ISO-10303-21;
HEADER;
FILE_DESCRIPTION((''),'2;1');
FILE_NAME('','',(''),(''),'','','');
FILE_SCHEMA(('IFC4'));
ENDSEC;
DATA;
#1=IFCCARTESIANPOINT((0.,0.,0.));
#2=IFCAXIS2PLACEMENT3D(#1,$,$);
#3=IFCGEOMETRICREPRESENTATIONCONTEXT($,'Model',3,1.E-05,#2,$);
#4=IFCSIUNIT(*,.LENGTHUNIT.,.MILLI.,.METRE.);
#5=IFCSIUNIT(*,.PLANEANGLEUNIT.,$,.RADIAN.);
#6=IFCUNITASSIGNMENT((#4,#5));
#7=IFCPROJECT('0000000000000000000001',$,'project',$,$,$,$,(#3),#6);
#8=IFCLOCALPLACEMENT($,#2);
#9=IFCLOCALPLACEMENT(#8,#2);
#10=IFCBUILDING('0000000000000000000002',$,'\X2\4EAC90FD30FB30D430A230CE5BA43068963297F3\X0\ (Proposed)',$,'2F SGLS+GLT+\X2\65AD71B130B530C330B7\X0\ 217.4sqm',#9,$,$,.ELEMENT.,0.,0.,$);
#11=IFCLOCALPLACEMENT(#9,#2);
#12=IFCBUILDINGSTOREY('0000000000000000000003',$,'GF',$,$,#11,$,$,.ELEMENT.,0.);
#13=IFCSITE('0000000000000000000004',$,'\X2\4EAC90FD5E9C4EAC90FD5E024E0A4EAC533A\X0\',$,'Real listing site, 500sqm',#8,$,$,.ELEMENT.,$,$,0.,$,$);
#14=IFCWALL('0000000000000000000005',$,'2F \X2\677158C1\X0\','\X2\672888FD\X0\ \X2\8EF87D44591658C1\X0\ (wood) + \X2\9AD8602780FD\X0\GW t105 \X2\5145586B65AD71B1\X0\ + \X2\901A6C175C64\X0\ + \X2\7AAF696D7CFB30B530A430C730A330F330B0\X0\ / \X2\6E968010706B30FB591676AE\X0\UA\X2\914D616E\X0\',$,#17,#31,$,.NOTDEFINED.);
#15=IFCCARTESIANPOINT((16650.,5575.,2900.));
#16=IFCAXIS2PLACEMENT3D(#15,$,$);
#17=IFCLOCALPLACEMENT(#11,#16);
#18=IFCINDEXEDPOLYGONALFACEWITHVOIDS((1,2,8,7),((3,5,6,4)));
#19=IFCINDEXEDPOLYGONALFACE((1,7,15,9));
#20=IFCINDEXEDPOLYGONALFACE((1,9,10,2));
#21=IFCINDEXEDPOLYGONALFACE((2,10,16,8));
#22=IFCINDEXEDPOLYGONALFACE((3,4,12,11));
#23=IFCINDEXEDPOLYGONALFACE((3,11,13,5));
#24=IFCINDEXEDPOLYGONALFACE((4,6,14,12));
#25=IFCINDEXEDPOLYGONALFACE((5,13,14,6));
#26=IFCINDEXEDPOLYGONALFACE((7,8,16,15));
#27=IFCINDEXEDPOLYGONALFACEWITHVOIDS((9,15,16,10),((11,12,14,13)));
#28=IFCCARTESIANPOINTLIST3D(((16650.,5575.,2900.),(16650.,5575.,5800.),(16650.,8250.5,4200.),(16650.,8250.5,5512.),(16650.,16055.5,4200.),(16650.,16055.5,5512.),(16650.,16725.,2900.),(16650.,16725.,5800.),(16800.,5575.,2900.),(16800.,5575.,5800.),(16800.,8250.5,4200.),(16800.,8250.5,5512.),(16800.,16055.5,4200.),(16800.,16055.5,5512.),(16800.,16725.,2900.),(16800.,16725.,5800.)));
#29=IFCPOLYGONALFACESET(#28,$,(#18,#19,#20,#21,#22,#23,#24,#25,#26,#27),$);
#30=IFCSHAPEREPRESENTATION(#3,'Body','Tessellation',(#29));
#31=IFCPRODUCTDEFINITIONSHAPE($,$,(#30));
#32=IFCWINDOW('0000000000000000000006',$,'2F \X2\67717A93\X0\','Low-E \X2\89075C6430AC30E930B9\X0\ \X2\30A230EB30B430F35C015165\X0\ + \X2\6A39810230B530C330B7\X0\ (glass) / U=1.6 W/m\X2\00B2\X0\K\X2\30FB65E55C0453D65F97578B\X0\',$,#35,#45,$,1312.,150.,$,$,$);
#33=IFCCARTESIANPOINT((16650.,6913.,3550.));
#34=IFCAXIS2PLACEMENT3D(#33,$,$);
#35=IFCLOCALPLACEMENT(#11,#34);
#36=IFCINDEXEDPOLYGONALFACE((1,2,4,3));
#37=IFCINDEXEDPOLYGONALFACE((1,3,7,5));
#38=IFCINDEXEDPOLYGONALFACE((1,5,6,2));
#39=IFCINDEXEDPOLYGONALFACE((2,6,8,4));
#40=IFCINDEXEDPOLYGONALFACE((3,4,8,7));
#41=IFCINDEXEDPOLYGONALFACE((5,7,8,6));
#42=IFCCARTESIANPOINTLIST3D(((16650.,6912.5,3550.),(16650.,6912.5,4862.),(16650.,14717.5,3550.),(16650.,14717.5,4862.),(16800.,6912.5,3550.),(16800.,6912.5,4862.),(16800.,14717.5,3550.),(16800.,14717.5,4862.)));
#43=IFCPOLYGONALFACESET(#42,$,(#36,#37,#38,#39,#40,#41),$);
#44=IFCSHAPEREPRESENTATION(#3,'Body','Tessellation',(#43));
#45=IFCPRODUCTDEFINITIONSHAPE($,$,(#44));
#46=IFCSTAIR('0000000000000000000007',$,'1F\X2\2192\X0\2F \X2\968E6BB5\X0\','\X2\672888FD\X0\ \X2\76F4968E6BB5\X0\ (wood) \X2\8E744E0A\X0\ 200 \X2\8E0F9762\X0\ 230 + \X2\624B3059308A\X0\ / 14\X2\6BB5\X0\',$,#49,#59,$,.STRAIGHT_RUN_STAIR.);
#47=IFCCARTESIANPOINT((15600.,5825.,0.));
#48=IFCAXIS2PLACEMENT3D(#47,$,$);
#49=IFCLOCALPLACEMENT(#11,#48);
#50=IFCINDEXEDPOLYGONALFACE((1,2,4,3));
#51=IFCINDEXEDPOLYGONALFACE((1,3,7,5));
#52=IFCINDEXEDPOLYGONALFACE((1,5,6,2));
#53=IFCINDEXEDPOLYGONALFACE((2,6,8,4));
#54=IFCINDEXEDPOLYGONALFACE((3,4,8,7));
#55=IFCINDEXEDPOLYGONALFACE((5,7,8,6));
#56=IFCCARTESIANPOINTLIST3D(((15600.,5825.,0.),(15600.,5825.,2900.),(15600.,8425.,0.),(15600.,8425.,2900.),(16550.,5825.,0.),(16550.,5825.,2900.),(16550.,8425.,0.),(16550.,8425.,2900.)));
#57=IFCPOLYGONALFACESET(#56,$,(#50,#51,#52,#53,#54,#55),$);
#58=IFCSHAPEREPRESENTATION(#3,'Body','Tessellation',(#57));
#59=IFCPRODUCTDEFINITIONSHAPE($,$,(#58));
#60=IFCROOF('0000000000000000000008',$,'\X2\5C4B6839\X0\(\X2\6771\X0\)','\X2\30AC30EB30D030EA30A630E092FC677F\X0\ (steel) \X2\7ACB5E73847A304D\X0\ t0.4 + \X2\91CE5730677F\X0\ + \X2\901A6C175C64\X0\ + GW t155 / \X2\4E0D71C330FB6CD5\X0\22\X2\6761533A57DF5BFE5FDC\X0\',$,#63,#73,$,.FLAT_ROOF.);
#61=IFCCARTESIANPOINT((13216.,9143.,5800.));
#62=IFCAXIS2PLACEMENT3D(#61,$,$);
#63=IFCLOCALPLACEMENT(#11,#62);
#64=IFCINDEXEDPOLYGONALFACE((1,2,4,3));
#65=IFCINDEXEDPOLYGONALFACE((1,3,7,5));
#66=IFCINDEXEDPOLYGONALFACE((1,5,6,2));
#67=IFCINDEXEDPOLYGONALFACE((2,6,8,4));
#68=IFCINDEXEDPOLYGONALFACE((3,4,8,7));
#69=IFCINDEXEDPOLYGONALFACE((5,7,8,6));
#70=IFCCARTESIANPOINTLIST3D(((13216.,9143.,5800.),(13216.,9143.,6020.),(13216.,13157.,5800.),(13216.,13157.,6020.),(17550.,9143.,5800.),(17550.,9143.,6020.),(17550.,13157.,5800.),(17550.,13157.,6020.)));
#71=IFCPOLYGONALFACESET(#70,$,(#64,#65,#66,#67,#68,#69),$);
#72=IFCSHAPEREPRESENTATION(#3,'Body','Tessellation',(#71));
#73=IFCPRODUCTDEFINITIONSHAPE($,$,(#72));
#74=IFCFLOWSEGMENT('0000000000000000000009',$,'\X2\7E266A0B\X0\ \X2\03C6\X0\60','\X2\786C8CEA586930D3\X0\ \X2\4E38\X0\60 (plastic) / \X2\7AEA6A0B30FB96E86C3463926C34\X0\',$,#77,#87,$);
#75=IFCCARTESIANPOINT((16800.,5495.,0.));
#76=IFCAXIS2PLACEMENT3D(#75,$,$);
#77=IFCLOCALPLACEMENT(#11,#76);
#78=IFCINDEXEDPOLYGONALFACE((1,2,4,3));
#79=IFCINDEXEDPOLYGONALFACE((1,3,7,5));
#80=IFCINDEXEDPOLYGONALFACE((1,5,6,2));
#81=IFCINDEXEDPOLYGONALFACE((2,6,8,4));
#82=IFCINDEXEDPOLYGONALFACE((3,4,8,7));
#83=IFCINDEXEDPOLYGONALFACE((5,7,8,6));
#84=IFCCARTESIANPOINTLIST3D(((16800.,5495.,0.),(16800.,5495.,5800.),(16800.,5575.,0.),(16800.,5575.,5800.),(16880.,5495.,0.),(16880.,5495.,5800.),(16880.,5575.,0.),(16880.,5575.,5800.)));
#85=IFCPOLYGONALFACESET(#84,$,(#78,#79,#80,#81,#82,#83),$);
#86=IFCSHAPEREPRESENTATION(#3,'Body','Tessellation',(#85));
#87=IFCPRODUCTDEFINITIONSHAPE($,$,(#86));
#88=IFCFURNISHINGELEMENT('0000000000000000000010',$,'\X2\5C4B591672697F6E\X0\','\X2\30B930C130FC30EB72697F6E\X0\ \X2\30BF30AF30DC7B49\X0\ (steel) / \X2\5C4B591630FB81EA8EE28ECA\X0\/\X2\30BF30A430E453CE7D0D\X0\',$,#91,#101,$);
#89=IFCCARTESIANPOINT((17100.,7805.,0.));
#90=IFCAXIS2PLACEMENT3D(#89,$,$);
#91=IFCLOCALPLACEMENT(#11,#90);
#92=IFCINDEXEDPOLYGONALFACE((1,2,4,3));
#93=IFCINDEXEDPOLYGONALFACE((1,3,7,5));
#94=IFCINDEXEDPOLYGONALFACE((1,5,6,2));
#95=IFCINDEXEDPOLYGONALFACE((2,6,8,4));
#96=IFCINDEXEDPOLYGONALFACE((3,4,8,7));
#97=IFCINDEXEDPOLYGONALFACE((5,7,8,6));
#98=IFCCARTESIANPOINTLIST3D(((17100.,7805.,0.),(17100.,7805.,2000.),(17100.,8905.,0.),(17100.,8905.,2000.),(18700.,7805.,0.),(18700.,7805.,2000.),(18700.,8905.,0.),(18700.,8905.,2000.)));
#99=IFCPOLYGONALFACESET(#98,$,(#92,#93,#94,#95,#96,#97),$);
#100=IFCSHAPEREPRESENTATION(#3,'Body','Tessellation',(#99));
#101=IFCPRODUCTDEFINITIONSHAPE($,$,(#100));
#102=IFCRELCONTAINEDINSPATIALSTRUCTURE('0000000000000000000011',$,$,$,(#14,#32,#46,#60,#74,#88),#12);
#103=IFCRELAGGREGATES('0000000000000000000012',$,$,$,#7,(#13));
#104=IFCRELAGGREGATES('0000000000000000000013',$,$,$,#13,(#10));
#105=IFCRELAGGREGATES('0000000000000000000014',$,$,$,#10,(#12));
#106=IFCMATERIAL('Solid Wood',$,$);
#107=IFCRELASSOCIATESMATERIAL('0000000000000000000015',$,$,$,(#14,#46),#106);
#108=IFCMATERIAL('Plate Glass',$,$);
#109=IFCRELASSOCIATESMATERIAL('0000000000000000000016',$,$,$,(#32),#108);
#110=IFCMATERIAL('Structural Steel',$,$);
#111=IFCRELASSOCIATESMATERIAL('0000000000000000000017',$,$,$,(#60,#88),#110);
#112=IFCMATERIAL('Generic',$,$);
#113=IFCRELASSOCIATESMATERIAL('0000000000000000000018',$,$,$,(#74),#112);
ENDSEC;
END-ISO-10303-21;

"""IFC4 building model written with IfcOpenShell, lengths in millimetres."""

from ifc_helpers import new_model, si_unit, frame, frame_2d, origin, place, context, project, spatial, rectangle, extrude, material, element, fill, save


model = new_model("IFC4")

# Units and contexts
model_context = context("Model", 3, precision=1e-05, world=origin())
ifc_project = project(units=[si_unit("LENGTHUNIT", "METRE", prefix="MILLI"), si_unit("PLANEANGLEUNIT", "RADIAN")], contexts=[model_context])

# Site, building, storey
site_placement = place(None, origin())
site = spatial("IfcSite", under=ifc_project, at=site_placement, Name="京都府京都市上京区", ObjectType="Real listing site, 500sqm", CompositionType="ELEMENT", RefElevation=0.0)
building_placement = place(site_placement, origin())
building = spatial("IfcBuilding", under=site, at=building_placement, Name="京都・ピアノ室と防音 (Proposed)", ObjectType="2F SGLS+GLT+断熱サッシ 217.4sqm", CompositionType="ELEMENT", ElevationOfRefHeight=0.0, ElevationOfTerrain=0.0)
storey_placement = place(building_placement, origin())
storey = spatial("IfcBuildingStorey", under=building, at=storey_placement, Name="GF", CompositionType="ELEMENT", Elevation=0.0)

# Shared definitions
ifc_material_1 = material(Name="Solid Wood")

# Wall, opening, window
ifc_material_2 = material(Name="Plate Glass")
wall_1_placement = place(storey_placement, frame((16650.0, 5575.0, 2900.0)))
wall_1 = element("IfcWall", 1, at=wall_1_placement, inside=storey, material=ifc_material_1, Name="2F 東壁", Description="木製 軸組外壁 (wood) + 高性能GW t105 充填断熱 + 通気層 + 窯業系サイディング / 準耐火・外皮UA配慮", PredefinedType="NOTDEFINED", context=model_context, shape_type="SweptSolid", body=[
    extrude(rectangle(XDim=150.0, YDim=11150.0, at=frame_2d((75.0, 5575.0))), frame((16650.0, 5575.0, 2900.0)), (0.0, 0.0, 1.0), 2900.0),
])
opening_1_placement = place(storey_placement, frame((16650.0, 6913.0, 3550.0)))
opening_1 = element("IfcOpeningElement", 2, at=opening_1_placement, cuts=wall_1, PredefinedType="NOTDEFINED", context=model_context, shape_type="SweptSolid", body=[
    extrude(rectangle(XDim=150.0, YDim=7805.0, at=frame_2d((75.0, 3902.0))), frame((16650.0, 6913.0, 3550.0)), (0.0, 0.0, 1.0), 1312.0),
])
window_1_placement = place(storey_placement, frame((16650.0, 6913.0, 3550.0)))
window_1 = element("IfcWindow", 3, at=window_1_placement, inside=storey, material=ifc_material_2, Name="2F 東窓", Description="Low-E 複層ガラス アルゴン封入 + 樹脂サッシ (glass) / U=1.6 W/m²K・日射取得型", OverallHeight=1312.0, OverallWidth=150.0, context=model_context, shape_type="SweptSolid", body=[
    extrude(rectangle(XDim=150.0, YDim=7805.0, at=frame_2d((75.0, 3902.0))), frame((16650.0, 6913.0, 3550.0)), (0.0, 0.0, 1.0), 1312.0),
])
fill(opening_1, window_1)

# Stair
stair_placement = place(storey_placement, frame((15600.0, 5825.0, 0.0)))
element("IfcStair", 4, at=stair_placement, inside=storey, material=ifc_material_1, Name="1F→2F 階段", Description="木製 直階段 (wood) 蹴上 200 踏面 230 + 手すり / 14段", PredefinedType="STRAIGHT_RUN_STAIR", context=model_context, shape_type="SweptSolid", body=[
    extrude(rectangle(XDim=950.0, YDim=2600.0, at=frame_2d((475.0, 1300.0))), frame((15600.0, 5825.0, 0.0)), (0.0, 0.0, 1.0), 2900.0),
])

# Roof
ifc_material_3 = material(Name="Structural Steel")
roof_placement = place(storey_placement, frame((13216.0, 9143.0, 5800.0)))
element("IfcRoof", 5, at=roof_placement, inside=storey, material=ifc_material_3, Name="屋根(東)", Description="ガルバリウム鋼板 (steel) 立平葺き t0.4 + 野地板 + 通気層 + GW t155 / 不燃・法22条区域対応", PredefinedType="FLAT_ROOF", context=model_context, shape_type="SweptSolid", body=[
    extrude(rectangle(XDim=4334.0, YDim=4014.0, at=frame_2d((2167.0, 2007.0))), frame((13216.0, 9143.0, 5800.0)), (0.0, 0.0, 1.0), 220.0),
])

# Flow segment
ifc_material_4 = material(Name="Generic")
flow_segment_placement = place(storey_placement, frame((16800.0, 5495.0, 0.0)))
element("IfcFlowSegment", 6, at=flow_segment_placement, inside=storey, material=ifc_material_4, Name="縦樋 φ60", Description="硬質塩ビ 丸60 (plastic) / 竪樋・雨水排水", context=model_context, shape_type="SweptSolid", body=[
    extrude(rectangle(XDim=80.0, YDim=80.0, at=frame_2d((40.0, 40.0))), frame((16800.0, 5495.0, 0.0)), (0.0, 0.0, 1.0), 5800.0),
])

# Furnishing element
furnishing_placement = place(storey_placement, frame((17100.0, 7805.0, 0.0)))
element("IfcFurnishingElement", 7, at=furnishing_placement, inside=storey, material=ifc_material_3, Name="屋外物置", Description="スチール物置 タクボ等 (steel) / 屋外・自転車/タイヤ収納", context=model_context, shape_type="SweptSolid", body=[
    extrude(rectangle(XDim=1600.0, YDim=1100.0, at=frame_2d((800.0, 550.0))), frame((17100.0, 7805.0, 0.0)), (0.0, 0.0, 1.0), 2000.0),
])

save(model, "model.ifc")
